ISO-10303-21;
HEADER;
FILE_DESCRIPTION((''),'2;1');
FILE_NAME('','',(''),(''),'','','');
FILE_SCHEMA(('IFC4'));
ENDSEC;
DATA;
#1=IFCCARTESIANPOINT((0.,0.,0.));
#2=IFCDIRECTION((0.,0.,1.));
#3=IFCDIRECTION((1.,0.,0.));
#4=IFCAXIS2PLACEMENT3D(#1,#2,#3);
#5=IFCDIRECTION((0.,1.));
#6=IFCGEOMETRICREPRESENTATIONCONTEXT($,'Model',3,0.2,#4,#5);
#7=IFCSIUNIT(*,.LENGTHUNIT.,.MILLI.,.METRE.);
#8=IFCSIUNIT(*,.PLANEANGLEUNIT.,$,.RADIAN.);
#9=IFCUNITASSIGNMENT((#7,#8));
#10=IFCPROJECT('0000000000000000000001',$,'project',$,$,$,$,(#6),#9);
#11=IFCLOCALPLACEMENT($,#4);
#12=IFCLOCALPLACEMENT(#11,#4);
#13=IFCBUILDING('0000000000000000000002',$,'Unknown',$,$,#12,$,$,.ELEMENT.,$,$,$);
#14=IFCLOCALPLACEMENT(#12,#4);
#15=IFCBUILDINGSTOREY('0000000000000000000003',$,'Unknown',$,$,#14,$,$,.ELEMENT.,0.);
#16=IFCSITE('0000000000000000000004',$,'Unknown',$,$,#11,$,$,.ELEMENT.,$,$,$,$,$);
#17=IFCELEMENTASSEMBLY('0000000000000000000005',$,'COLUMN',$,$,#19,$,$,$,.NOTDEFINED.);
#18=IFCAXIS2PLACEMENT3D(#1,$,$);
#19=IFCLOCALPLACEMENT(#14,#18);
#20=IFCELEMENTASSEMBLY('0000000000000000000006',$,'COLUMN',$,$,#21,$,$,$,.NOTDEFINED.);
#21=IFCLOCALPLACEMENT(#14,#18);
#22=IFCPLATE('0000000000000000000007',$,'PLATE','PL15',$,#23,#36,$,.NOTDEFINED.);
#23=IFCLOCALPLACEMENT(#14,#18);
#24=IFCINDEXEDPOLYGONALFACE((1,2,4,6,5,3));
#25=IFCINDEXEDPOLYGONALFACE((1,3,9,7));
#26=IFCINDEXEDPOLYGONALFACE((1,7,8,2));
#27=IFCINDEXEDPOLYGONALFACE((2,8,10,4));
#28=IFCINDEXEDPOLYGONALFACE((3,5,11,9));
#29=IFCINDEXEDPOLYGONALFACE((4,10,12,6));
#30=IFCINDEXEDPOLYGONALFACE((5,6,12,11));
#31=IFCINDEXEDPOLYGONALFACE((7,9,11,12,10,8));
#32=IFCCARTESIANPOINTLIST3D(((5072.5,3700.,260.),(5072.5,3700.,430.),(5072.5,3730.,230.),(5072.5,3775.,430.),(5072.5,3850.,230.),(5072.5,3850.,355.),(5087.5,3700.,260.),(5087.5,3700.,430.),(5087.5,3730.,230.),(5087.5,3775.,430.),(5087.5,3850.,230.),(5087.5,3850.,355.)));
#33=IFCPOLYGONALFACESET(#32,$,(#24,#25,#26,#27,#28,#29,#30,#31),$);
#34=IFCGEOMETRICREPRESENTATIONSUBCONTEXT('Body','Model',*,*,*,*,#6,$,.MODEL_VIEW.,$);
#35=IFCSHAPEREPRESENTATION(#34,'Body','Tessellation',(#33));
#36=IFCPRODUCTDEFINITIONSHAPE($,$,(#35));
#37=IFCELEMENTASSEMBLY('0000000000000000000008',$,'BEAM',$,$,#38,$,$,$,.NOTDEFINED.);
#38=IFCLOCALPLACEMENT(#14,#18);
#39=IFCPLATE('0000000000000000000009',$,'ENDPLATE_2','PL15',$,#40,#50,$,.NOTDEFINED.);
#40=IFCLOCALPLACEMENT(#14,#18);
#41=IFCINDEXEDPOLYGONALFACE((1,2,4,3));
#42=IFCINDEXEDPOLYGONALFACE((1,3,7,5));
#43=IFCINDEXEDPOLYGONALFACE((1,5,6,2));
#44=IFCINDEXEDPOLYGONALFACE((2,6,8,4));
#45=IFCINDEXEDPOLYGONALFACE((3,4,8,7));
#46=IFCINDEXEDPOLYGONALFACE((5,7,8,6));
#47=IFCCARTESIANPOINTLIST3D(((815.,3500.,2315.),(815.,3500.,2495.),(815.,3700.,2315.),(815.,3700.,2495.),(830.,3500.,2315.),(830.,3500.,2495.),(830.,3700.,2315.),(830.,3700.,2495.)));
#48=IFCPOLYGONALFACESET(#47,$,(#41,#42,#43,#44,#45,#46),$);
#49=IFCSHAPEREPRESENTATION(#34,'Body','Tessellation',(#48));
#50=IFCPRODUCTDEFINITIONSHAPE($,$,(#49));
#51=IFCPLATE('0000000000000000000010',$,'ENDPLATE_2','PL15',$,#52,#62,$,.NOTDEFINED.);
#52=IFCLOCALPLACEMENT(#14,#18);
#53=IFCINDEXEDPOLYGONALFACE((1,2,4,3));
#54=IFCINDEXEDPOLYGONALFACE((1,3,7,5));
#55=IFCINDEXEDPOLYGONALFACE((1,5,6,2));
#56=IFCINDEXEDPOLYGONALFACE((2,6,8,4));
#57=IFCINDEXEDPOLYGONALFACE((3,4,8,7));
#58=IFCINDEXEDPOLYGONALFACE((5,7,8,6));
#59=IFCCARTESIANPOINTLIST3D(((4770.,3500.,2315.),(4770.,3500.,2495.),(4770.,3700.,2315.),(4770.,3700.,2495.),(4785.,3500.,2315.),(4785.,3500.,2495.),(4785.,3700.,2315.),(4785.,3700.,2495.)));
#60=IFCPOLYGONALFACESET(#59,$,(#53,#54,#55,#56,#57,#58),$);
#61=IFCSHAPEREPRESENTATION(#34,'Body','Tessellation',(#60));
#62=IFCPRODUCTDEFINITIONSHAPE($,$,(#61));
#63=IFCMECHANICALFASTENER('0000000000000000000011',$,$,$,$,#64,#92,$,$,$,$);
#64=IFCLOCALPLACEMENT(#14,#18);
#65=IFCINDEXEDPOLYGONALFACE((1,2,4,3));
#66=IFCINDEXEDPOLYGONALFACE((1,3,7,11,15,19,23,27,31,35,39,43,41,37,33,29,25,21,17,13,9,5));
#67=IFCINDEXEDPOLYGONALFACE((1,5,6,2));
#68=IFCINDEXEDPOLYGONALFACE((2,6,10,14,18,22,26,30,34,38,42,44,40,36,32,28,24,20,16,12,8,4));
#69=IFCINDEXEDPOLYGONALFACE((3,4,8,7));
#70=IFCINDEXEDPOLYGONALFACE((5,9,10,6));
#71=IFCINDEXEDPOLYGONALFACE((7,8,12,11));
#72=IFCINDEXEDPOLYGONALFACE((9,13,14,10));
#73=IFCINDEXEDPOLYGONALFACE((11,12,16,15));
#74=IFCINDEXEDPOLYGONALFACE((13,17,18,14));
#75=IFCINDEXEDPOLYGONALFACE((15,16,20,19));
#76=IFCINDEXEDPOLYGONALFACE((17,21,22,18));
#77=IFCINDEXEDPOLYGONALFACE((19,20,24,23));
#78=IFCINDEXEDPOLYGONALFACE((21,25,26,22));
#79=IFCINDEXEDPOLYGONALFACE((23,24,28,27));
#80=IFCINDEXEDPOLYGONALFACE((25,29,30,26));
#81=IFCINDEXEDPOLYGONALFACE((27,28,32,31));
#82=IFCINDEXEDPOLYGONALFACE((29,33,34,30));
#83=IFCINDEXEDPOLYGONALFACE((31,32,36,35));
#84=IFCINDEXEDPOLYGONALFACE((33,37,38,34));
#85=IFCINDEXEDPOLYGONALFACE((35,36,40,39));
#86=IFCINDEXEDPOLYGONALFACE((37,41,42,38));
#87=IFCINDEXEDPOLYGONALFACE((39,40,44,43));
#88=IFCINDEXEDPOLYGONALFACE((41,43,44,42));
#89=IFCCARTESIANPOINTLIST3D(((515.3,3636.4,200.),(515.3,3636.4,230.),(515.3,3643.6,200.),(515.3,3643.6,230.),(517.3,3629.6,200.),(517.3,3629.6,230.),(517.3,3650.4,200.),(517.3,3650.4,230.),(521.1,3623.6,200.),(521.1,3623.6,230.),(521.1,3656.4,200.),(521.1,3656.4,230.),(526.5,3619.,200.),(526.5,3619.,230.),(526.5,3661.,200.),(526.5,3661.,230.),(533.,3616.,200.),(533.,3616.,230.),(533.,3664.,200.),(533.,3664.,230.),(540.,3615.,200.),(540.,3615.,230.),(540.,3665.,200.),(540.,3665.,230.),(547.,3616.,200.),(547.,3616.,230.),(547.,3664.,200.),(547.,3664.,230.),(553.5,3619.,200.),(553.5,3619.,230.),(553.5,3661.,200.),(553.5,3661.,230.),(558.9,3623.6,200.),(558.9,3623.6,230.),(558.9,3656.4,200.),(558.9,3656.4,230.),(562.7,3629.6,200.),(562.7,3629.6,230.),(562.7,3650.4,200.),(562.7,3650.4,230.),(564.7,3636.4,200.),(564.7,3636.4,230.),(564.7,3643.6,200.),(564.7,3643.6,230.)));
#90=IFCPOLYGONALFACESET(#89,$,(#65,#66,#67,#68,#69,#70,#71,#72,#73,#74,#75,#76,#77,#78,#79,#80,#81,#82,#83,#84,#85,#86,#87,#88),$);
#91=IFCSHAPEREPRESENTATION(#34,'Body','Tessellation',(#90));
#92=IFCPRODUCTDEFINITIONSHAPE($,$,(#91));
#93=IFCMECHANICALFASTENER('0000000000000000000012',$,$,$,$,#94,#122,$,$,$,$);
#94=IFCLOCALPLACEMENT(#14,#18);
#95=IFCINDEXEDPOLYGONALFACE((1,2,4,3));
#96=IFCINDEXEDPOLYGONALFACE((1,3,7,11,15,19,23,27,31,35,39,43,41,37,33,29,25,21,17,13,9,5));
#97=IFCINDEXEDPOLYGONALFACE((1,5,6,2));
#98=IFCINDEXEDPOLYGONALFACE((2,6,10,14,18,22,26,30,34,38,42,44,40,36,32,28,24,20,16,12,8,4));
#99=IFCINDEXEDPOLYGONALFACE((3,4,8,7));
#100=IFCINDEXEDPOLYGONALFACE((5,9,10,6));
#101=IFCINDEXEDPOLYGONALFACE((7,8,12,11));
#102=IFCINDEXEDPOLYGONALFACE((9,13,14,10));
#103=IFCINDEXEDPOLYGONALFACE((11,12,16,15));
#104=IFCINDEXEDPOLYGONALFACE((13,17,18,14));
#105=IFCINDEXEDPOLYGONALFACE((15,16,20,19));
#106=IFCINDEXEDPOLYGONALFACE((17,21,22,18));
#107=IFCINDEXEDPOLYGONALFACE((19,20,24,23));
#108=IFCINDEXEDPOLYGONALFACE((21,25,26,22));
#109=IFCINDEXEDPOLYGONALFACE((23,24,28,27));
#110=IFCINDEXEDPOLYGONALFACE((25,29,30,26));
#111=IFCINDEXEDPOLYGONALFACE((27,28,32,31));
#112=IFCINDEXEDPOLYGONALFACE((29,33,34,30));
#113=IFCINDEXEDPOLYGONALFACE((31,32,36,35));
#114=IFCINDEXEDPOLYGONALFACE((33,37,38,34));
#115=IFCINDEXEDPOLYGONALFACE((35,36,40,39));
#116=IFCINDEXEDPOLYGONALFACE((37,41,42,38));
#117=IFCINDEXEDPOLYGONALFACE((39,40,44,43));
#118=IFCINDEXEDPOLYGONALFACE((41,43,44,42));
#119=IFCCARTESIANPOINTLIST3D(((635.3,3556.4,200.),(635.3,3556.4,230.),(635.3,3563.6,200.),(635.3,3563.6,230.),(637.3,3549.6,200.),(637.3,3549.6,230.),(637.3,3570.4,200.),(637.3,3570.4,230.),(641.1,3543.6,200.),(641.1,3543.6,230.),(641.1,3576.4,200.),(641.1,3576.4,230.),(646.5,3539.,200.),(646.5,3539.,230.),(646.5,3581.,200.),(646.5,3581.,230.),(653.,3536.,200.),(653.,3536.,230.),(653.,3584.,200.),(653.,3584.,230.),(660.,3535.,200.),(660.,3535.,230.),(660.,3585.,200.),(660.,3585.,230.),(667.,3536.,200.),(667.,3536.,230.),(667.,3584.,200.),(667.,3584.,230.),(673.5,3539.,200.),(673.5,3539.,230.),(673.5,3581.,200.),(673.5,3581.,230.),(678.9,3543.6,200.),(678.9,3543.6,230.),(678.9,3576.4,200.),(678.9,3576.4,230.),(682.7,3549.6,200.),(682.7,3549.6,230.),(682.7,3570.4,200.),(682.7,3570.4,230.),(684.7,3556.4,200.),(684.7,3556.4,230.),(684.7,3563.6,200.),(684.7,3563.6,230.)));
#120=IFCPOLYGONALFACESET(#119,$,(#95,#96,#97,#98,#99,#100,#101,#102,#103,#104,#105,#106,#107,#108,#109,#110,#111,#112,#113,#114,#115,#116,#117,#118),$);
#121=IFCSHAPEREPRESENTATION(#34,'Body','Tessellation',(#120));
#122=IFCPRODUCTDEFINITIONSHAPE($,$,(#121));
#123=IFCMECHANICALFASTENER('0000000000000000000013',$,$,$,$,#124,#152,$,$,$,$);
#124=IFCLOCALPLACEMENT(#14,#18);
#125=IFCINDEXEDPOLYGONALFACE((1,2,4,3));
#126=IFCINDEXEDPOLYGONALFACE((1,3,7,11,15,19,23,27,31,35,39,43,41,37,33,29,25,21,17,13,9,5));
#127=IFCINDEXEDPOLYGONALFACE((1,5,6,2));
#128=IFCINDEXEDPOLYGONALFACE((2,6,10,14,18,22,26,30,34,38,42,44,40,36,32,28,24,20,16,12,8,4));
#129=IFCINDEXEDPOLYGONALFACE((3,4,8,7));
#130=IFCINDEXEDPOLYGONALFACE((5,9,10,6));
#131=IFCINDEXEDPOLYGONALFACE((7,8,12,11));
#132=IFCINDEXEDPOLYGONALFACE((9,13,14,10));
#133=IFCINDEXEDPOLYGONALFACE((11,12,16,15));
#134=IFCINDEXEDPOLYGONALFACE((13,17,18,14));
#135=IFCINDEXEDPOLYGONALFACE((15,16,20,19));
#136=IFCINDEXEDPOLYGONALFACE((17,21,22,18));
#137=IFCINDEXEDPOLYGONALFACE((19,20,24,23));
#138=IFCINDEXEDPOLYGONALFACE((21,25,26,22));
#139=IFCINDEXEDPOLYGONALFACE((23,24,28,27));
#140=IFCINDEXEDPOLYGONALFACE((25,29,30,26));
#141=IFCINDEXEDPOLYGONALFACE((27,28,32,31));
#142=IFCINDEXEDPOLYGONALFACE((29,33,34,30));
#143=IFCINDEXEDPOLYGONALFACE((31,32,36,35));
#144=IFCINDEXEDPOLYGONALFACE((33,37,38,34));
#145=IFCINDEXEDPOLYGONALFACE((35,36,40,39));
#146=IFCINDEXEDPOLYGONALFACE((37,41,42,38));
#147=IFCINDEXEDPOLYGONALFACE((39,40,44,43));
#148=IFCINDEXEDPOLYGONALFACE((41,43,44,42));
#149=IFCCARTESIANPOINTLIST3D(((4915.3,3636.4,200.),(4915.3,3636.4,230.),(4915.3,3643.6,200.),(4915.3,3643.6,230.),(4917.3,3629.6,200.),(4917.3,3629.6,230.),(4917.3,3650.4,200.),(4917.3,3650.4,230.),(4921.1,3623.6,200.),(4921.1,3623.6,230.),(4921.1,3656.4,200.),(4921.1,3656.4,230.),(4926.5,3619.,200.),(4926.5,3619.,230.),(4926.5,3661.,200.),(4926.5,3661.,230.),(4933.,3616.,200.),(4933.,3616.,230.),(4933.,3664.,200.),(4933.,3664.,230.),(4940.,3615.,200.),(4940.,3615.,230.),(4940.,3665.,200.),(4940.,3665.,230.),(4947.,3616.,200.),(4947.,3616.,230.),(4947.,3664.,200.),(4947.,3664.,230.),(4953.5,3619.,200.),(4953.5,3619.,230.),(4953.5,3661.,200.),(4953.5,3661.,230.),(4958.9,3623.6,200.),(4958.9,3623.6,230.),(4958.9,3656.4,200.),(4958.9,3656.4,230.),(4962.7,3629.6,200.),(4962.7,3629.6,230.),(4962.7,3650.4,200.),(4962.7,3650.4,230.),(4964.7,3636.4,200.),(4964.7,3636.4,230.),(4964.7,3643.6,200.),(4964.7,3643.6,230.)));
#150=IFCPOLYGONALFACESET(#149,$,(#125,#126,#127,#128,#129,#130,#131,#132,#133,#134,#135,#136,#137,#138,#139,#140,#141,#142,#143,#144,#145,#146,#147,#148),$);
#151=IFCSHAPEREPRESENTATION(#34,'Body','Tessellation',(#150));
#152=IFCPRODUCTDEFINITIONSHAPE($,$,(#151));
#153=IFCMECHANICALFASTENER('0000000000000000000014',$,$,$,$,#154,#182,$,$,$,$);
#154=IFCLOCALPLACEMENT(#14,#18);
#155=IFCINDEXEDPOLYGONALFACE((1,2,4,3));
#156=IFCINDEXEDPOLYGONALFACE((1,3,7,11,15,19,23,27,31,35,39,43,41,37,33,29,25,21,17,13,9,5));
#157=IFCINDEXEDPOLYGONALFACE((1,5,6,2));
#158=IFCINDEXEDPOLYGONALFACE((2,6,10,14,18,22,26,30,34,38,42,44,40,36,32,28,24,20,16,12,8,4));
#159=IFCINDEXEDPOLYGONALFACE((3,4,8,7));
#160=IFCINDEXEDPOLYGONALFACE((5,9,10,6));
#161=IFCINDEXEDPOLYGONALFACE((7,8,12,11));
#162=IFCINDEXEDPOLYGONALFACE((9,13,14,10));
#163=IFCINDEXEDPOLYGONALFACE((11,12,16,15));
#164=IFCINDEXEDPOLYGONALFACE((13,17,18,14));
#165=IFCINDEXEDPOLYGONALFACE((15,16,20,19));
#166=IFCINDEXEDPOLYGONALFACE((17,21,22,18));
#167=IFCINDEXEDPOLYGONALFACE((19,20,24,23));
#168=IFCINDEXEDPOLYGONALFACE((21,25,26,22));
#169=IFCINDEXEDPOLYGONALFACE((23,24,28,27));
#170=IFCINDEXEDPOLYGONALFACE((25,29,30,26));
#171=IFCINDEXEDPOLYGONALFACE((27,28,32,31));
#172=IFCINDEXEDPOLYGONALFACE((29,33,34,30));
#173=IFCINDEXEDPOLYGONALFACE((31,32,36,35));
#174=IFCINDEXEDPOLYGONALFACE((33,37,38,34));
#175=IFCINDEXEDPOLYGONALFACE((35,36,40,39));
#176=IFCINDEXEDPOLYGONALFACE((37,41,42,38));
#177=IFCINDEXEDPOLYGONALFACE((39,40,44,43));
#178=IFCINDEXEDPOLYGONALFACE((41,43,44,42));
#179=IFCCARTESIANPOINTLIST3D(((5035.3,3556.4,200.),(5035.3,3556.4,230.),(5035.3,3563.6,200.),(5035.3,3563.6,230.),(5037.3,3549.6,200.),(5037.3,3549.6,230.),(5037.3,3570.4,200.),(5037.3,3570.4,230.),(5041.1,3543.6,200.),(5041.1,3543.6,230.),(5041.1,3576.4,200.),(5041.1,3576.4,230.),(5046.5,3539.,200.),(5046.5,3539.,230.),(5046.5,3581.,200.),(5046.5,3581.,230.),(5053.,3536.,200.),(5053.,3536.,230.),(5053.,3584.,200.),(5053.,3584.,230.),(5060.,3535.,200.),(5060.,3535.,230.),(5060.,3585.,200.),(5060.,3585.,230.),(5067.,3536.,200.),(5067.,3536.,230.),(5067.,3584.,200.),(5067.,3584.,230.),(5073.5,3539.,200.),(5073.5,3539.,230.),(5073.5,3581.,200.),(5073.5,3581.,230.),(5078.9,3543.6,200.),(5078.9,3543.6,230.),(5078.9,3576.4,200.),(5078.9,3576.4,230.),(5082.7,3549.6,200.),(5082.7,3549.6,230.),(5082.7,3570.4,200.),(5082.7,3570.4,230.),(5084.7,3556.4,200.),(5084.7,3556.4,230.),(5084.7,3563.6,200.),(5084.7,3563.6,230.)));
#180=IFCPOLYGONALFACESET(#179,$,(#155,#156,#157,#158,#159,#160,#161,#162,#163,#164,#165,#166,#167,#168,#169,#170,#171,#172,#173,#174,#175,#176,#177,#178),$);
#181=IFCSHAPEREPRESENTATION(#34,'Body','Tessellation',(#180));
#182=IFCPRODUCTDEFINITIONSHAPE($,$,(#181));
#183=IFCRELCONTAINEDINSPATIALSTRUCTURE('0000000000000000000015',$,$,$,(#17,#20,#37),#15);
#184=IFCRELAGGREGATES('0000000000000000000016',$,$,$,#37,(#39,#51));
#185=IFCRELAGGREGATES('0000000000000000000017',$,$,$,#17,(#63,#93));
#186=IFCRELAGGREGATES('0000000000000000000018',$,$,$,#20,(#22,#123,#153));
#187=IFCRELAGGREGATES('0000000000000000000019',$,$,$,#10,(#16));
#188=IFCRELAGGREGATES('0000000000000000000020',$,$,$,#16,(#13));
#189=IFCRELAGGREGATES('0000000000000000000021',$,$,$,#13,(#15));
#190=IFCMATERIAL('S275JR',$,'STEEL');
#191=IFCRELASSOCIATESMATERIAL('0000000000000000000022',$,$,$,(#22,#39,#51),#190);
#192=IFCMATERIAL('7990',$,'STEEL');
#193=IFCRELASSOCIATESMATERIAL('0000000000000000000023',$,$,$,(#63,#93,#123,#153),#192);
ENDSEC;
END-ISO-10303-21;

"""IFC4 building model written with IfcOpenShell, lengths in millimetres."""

from ifc_helpers import new_model, si_unit, direction, frame, origin_with_axes, place, context, subcontext, project, spatial, line, arc, indexed_curve, outline, extrude, source, transform, mapped, material, element, aggregate, save


model = new_model("IFC4")

# Units and contexts
model_context = context("Model", 3, precision=0.2, world=origin_with_axes(), true_north=direction((0.0, 1.0)))
body_context = subcontext(model_context, "Body", "Model", "MODEL_VIEW")
ifc_project = project(units=[si_unit("LENGTHUNIT", "METRE", prefix="MILLI"), si_unit("PLANEANGLEUNIT", "RADIAN")], contexts=[model_context])

# Site, building, storey
site_placement = place(None, origin_with_axes())
site = spatial("IfcSite", under=ifc_project, at=site_placement, Name="Unknown", CompositionType="ELEMENT")
building_placement = place(site_placement, origin_with_axes())
building = spatial("IfcBuilding", under=site, at=building_placement, Name="Unknown", CompositionType="ELEMENT")
storey_placement = place(building_placement, origin_with_axes())
storey = spatial("IfcBuildingStorey", under=building, at=storey_placement, Name="Unknown", CompositionType="ELEMENT", Elevation=0.0)

# Element assemblies
assembly_1_placement = place(storey_placement, frame((600.0, 3600.0, 200.0), z_axis=(-1.0, 0.0, 0.0), x_axis=(0.0, 0.0, 1.0)))
assembly_1 = element("IfcElementAssembly", 1, at=assembly_1_placement, inside=storey, Name="COLUMN", PredefinedType="NOTDEFINED")
ifc_material_1 = material(Name="S275JR", Category="STEEL")
assembly_2_placement = place(storey_placement, frame((5000.0, 3600.0, 200.0), z_axis=(-1.0, 0.0, 0.0), x_axis=(0.0, 0.0, 1.0)))
assembly_2 = element("IfcElementAssembly", 2, at=assembly_2_placement, inside=storey, Name="COLUMN", PredefinedType="NOTDEFINED")

# Plate
plate_1_placement = place(assembly_2_placement, frame((60.0, 100.0, -80.0), z_axis=(0.0, -0.000002, -1.0), x_axis=(-0.707113, 0.707101, 0.0)))
plate_1 = element("IfcPlate", 3, at=plate_1_placement, material=ifc_material_1, Name="PLATE", Description="PL15", PredefinedType="NOTDEFINED", context=body_context, shape_type="SolidModel", body=[
    extrude(outline(indexed_curve([(0.0, 0.0), (42.4, 0.0), (127.3, 84.9), (38.9, 173.2), (-67.2, 173.2), (-120.2, 120.2)], segments=[line(1, 2, 3, 4, 5, 6, 1)])), frame((0.0, 0.0, 7.5), z_axis=(0.0, 0.0, 1.0), x_axis=(1.0, 0.0, 0.0)), (0.0, -0.000002, -1.0), 15.0),
])

# Element assembly, plates
assembly_3_placement = place(storey_placement, frame((600.0, 3600.0, 2405.0), z_axis=(-0.000002, -1.0, 0.0), x_axis=(1.0, 0.0, 0.0)))
assembly_3 = element("IfcElementAssembly", 4, at=assembly_3_placement, inside=storey, Name="BEAM", PredefinedType="NOTDEFINED")
plate_2_placement = place(assembly_3_placement, frame((222.5, -90.0, -100.0), z_axis=(1.0, 0.0, 0.0), x_axis=(0.0, 1.0, 0.0)))
plate_2 = element("IfcPlate", 5, at=plate_2_placement, material=ifc_material_1, Name="ENDPLATE_2", Description="PL15", PredefinedType="NOTDEFINED", context=body_context, shape_type="SolidModel", body=[
    extrude(outline(indexed_curve([(0.0, 0.0), (180.0, 0.0), (180.0, 200.0), (0.0, 200.0)], segments=[line(1, 2, 3, 4, 1)])), frame((0.0, 0.0, 7.5), z_axis=(0.0, 0.0, 1.0), x_axis=(1.0, 0.0, 0.0)), (0.0, -0.000002, -1.0), 15.0),
])
plate_3_placement = place(assembly_3_placement, frame((4177.5, -90.0, 100.0), z_axis=(-1.0, 0.0, 0.0), x_axis=(0.0, 1.0, 0.0)))
plate_3 = element("IfcPlate", 6, at=plate_3_placement, material=ifc_material_1, Name="ENDPLATE_2", Description="PL15", PredefinedType="NOTDEFINED", context=body_context, shape_type="SolidModel", body=[
    extrude(outline(indexed_curve([(0.0, 0.0), (180.0, 0.0), (180.0, 200.0), (0.0, 200.0)], segments=[line(1, 2, 3, 4, 1)])), frame((0.0, 0.0, 7.5), z_axis=(0.0, 0.0, 1.0), x_axis=(1.0, 0.0, 0.0)), (0.0, -0.000002, -1.0), 15.0),
])
aggregate(assembly_3, [plate_2, plate_3])

# Mechanical fasteners
ifc_material_2 = material(Name="7990", Category="STEEL")
shared_shape_1 = source(origin_with_axes(), body_context, "Body", "SweptSolid", [
    extrude(outline(indexed_curve([(25.0, 0.0), (0.0, 25.0), (-25.0, 0.0), (0.0, -25.0)], segments=[arc(1, 2, 3), arc(3, 4, 1)])), frame((0.0, 0.0, 0.0), z_axis=(0.0, -0.000002, -1.0), x_axis=(0.0, 1.0, 0.0)), (0.0, 0.0, 1.0), 30.0),
])
mechanical_fastener_1_placement = place(assembly_1_placement, frame((30.0, 40.0, 60.0), z_axis=(1.0, 0.0, 0.0), x_axis=(0.0, -0.000002, -1.0)))
mechanical_fastener_1 = element("IfcMechanicalFastener", 7, at=mechanical_fastener_1_placement, material=ifc_material_2, context=body_context, shape_type="MappedRepresentation", body=[
    mapped(shared_shape_1, transform((0.0, 0.0, 0.0))),
])
mechanical_fastener_2_placement = place(assembly_1_placement, frame((30.0, -40.0, -60.0), z_axis=(1.0, 0.0, 0.0), x_axis=(0.0, -0.000002, -1.0)))
mechanical_fastener_2 = element("IfcMechanicalFastener", 8, at=mechanical_fastener_2_placement, material=ifc_material_2, context=body_context, shape_type="MappedRepresentation", body=[
    mapped(shared_shape_1, transform((0.0, 0.0, 0.0))),
])
aggregate(assembly_1, [mechanical_fastener_1, mechanical_fastener_2])
mechanical_fastener_3_placement = place(assembly_2_placement, frame((30.0, 40.0, 60.0), z_axis=(1.0, 0.0, 0.0), x_axis=(0.0, -0.000002, -1.0)))
mechanical_fastener_3 = element("IfcMechanicalFastener", 9, at=mechanical_fastener_3_placement, material=ifc_material_2, context=body_context, shape_type="MappedRepresentation", body=[
    mapped(shared_shape_1, transform((0.0, 0.0, 0.0))),
])
mechanical_fastener_4_placement = place(assembly_2_placement, frame((30.0, -40.0, -60.0), z_axis=(1.0, 0.0, 0.0), x_axis=(0.0, -0.000002, -1.0)))
mechanical_fastener_4 = element("IfcMechanicalFastener", 10, at=mechanical_fastener_4_placement, material=ifc_material_2, context=body_context, shape_type="MappedRepresentation", body=[
    mapped(shared_shape_1, transform((0.0, 0.0, 0.0))),
])
aggregate(assembly_2, [plate_1, mechanical_fastener_3, mechanical_fastener_4])

save(model, "model.ifc")
